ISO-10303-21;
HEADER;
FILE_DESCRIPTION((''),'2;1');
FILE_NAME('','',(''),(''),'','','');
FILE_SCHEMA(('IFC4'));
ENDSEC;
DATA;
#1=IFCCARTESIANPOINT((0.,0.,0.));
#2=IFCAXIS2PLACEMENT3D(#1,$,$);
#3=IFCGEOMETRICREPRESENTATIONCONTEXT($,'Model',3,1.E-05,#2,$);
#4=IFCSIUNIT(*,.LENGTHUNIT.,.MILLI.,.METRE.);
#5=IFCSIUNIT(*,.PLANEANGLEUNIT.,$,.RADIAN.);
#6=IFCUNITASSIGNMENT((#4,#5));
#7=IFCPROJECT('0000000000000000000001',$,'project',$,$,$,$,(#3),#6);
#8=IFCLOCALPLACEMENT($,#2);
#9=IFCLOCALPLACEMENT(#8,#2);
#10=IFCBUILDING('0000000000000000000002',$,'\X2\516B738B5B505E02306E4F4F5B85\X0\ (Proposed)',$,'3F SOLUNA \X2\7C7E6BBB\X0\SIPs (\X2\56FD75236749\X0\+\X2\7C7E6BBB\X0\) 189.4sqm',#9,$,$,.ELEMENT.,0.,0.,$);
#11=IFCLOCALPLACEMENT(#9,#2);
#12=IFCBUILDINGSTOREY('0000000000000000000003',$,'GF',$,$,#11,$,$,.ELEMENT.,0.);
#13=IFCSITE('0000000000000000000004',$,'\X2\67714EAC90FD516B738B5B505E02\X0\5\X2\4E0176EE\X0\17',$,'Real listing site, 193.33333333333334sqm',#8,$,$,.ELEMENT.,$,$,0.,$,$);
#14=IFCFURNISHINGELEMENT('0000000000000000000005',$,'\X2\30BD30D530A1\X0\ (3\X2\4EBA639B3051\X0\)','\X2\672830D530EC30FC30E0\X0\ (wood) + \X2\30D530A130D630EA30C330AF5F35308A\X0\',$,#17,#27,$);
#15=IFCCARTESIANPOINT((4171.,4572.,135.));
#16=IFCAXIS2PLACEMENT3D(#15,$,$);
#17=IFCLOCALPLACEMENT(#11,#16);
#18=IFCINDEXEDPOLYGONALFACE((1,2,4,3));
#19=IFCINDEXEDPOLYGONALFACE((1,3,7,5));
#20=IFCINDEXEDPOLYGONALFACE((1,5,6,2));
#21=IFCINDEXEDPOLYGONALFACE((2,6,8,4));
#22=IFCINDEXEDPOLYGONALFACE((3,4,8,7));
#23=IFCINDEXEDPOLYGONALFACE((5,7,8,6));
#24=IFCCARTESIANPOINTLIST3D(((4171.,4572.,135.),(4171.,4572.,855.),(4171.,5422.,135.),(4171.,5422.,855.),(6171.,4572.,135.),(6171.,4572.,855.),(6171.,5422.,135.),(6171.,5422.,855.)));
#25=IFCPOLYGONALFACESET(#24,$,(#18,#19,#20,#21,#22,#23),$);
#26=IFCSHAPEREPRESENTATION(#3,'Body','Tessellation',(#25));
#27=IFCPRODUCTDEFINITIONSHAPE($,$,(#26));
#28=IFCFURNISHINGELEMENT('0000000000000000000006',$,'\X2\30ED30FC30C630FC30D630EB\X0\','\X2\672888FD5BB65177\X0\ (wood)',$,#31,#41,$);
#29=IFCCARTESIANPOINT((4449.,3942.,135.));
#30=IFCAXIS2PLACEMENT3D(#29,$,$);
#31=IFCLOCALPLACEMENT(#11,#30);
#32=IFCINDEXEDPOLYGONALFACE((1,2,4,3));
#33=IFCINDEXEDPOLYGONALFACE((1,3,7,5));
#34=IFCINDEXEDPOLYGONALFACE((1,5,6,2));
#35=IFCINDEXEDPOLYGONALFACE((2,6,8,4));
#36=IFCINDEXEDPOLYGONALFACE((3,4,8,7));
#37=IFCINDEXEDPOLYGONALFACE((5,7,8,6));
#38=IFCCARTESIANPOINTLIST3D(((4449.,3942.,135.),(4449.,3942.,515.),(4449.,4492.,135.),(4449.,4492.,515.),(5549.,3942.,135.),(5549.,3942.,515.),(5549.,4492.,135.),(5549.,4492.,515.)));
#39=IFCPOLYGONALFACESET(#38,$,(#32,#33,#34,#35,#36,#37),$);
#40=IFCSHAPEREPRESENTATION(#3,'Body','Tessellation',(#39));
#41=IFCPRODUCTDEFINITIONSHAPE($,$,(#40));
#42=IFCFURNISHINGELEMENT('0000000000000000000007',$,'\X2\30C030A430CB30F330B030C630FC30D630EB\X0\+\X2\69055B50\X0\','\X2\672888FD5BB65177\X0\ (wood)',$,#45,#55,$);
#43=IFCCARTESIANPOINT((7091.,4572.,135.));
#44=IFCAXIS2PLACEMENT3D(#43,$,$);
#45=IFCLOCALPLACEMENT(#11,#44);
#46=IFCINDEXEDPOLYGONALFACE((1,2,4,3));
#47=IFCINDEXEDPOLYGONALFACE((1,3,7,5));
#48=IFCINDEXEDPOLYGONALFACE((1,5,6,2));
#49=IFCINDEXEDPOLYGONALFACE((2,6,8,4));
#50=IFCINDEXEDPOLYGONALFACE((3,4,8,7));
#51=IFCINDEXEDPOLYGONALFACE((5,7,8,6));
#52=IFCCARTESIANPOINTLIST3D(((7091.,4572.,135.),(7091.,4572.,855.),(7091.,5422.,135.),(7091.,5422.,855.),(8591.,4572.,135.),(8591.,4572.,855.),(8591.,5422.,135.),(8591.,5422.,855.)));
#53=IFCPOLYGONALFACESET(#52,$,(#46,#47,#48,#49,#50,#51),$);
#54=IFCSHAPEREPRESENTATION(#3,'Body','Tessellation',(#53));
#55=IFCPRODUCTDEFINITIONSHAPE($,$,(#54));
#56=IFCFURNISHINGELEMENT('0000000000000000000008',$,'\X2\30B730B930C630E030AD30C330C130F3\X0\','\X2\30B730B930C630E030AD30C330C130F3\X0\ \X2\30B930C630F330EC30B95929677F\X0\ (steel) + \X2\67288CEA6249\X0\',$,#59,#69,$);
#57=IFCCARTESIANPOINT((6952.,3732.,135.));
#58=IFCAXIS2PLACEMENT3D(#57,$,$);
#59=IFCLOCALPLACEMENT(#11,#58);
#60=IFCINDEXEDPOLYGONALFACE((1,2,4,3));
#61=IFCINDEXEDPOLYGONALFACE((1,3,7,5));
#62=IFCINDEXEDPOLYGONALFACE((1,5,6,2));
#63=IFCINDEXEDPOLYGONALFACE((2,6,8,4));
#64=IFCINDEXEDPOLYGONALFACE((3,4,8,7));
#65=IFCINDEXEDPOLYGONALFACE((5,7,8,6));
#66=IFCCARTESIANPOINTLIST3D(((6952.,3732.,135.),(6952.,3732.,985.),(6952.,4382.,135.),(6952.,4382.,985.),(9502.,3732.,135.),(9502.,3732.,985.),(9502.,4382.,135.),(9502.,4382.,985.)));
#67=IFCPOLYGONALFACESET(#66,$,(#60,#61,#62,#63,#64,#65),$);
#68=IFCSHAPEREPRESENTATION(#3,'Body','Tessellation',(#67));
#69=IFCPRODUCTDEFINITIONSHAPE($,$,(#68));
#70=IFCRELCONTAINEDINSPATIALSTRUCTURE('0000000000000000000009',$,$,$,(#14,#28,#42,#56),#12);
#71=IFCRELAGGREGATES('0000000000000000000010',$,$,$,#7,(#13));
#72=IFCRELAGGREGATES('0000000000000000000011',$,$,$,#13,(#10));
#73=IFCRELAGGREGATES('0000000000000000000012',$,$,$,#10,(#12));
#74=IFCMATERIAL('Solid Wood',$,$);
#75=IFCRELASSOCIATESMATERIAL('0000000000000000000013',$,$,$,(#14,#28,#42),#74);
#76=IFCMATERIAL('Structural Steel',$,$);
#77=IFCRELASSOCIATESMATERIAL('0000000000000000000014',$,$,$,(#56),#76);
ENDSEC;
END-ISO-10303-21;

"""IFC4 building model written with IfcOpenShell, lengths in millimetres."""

from ifc_helpers import new_model, si_unit, frame, frame_2d, origin, place, context, project, spatial, rectangle, extrude, material, element, save


model = new_model("IFC4")

# Units and contexts
model_context = context("Model", 3, precision=1e-05, world=origin())
ifc_project = project(units=[si_unit("LENGTHUNIT", "METRE", prefix="MILLI"), si_unit("PLANEANGLEUNIT", "RADIAN")], contexts=[model_context])

# Site, building, storey
site_placement = place(None, origin())
site = spatial("IfcSite", under=ifc_project, at=site_placement, Name="東京都八王子市5丁目17", ObjectType="Real listing site, 193.33333333333334sqm", CompositionType="ELEMENT", RefElevation=0.0)
building_placement = place(site_placement, origin())
building = spatial("IfcBuilding", under=site, at=building_placement, Name="八王子市の住宅 (Proposed)", ObjectType="3F SOLUNA 籾殻SIPs (国産杉+籾殻) 189.4sqm", CompositionType="ELEMENT", ElevationOfRefHeight=0.0, ElevationOfTerrain=0.0)
storey_placement = place(building_placement, origin())
storey = spatial("IfcBuildingStorey", under=building, at=storey_placement, Name="GF", CompositionType="ELEMENT", Elevation=0.0)

# Shared definitions
ifc_material_1 = material(Name="Solid Wood")

# Furnishing elements
furnishing_1_placement = place(storey_placement, frame((4171.0, 4572.0, 135.0)))
element("IfcFurnishingElement", 1, at=furnishing_1_placement, inside=storey, material=ifc_material_1, Name="ソファ (3人掛け)", Description="木フレーム (wood) + ファブリック張り", context=model_context, shape_type="SweptSolid", body=[
    extrude(rectangle(XDim=2000.0, YDim=850.0, at=frame_2d((1000.0, 425.0))), frame((4171.0, 4572.0, 135.0)), (0.0, 0.0, 1.0), 720.0),
])
furnishing_2_placement = place(storey_placement, frame((4449.0, 3942.0, 135.0)))
element("IfcFurnishingElement", 2, at=furnishing_2_placement, inside=storey, material=ifc_material_1, Name="ローテーブル", Description="木製家具 (wood)", context=model_context, shape_type="SweptSolid", body=[
    extrude(rectangle(XDim=1100.0, YDim=550.0, at=frame_2d((550.0, 275.0))), frame((4449.0, 3942.0, 135.0)), (0.0, 0.0, 1.0), 380.0),
])
furnishing_3_placement = place(storey_placement, frame((7091.0, 4572.0, 135.0)))
element("IfcFurnishingElement", 3, at=furnishing_3_placement, inside=storey, material=ifc_material_1, Name="ダイニングテーブル+椅子", Description="木製家具 (wood)", context=model_context, shape_type="SweptSolid", body=[
    extrude(rectangle(XDim=1500.0, YDim=850.0, at=frame_2d((750.0, 425.0))), frame((7091.0, 4572.0, 135.0)), (0.0, 0.0, 1.0), 720.0),
])
ifc_material_2 = material(Name="Structural Steel")
furnishing_4_placement = place(storey_placement, frame((6952.0, 3732.0, 135.0)))
element("IfcFurnishingElement", 4, at=furnishing_4_placement, inside=storey, material=ifc_material_2, Name="システムキッチン", Description="システムキッチン ステンレス天板 (steel) + 木質扉", context=model_context, shape_type="SweptSolid", body=[
    extrude(rectangle(XDim=2550.0, YDim=650.0, at=frame_2d((1275.0, 325.0))), frame((6952.0, 3732.0, 135.0)), (0.0, 0.0, 1.0), 850.0),
])

save(model, "model.ifc")
